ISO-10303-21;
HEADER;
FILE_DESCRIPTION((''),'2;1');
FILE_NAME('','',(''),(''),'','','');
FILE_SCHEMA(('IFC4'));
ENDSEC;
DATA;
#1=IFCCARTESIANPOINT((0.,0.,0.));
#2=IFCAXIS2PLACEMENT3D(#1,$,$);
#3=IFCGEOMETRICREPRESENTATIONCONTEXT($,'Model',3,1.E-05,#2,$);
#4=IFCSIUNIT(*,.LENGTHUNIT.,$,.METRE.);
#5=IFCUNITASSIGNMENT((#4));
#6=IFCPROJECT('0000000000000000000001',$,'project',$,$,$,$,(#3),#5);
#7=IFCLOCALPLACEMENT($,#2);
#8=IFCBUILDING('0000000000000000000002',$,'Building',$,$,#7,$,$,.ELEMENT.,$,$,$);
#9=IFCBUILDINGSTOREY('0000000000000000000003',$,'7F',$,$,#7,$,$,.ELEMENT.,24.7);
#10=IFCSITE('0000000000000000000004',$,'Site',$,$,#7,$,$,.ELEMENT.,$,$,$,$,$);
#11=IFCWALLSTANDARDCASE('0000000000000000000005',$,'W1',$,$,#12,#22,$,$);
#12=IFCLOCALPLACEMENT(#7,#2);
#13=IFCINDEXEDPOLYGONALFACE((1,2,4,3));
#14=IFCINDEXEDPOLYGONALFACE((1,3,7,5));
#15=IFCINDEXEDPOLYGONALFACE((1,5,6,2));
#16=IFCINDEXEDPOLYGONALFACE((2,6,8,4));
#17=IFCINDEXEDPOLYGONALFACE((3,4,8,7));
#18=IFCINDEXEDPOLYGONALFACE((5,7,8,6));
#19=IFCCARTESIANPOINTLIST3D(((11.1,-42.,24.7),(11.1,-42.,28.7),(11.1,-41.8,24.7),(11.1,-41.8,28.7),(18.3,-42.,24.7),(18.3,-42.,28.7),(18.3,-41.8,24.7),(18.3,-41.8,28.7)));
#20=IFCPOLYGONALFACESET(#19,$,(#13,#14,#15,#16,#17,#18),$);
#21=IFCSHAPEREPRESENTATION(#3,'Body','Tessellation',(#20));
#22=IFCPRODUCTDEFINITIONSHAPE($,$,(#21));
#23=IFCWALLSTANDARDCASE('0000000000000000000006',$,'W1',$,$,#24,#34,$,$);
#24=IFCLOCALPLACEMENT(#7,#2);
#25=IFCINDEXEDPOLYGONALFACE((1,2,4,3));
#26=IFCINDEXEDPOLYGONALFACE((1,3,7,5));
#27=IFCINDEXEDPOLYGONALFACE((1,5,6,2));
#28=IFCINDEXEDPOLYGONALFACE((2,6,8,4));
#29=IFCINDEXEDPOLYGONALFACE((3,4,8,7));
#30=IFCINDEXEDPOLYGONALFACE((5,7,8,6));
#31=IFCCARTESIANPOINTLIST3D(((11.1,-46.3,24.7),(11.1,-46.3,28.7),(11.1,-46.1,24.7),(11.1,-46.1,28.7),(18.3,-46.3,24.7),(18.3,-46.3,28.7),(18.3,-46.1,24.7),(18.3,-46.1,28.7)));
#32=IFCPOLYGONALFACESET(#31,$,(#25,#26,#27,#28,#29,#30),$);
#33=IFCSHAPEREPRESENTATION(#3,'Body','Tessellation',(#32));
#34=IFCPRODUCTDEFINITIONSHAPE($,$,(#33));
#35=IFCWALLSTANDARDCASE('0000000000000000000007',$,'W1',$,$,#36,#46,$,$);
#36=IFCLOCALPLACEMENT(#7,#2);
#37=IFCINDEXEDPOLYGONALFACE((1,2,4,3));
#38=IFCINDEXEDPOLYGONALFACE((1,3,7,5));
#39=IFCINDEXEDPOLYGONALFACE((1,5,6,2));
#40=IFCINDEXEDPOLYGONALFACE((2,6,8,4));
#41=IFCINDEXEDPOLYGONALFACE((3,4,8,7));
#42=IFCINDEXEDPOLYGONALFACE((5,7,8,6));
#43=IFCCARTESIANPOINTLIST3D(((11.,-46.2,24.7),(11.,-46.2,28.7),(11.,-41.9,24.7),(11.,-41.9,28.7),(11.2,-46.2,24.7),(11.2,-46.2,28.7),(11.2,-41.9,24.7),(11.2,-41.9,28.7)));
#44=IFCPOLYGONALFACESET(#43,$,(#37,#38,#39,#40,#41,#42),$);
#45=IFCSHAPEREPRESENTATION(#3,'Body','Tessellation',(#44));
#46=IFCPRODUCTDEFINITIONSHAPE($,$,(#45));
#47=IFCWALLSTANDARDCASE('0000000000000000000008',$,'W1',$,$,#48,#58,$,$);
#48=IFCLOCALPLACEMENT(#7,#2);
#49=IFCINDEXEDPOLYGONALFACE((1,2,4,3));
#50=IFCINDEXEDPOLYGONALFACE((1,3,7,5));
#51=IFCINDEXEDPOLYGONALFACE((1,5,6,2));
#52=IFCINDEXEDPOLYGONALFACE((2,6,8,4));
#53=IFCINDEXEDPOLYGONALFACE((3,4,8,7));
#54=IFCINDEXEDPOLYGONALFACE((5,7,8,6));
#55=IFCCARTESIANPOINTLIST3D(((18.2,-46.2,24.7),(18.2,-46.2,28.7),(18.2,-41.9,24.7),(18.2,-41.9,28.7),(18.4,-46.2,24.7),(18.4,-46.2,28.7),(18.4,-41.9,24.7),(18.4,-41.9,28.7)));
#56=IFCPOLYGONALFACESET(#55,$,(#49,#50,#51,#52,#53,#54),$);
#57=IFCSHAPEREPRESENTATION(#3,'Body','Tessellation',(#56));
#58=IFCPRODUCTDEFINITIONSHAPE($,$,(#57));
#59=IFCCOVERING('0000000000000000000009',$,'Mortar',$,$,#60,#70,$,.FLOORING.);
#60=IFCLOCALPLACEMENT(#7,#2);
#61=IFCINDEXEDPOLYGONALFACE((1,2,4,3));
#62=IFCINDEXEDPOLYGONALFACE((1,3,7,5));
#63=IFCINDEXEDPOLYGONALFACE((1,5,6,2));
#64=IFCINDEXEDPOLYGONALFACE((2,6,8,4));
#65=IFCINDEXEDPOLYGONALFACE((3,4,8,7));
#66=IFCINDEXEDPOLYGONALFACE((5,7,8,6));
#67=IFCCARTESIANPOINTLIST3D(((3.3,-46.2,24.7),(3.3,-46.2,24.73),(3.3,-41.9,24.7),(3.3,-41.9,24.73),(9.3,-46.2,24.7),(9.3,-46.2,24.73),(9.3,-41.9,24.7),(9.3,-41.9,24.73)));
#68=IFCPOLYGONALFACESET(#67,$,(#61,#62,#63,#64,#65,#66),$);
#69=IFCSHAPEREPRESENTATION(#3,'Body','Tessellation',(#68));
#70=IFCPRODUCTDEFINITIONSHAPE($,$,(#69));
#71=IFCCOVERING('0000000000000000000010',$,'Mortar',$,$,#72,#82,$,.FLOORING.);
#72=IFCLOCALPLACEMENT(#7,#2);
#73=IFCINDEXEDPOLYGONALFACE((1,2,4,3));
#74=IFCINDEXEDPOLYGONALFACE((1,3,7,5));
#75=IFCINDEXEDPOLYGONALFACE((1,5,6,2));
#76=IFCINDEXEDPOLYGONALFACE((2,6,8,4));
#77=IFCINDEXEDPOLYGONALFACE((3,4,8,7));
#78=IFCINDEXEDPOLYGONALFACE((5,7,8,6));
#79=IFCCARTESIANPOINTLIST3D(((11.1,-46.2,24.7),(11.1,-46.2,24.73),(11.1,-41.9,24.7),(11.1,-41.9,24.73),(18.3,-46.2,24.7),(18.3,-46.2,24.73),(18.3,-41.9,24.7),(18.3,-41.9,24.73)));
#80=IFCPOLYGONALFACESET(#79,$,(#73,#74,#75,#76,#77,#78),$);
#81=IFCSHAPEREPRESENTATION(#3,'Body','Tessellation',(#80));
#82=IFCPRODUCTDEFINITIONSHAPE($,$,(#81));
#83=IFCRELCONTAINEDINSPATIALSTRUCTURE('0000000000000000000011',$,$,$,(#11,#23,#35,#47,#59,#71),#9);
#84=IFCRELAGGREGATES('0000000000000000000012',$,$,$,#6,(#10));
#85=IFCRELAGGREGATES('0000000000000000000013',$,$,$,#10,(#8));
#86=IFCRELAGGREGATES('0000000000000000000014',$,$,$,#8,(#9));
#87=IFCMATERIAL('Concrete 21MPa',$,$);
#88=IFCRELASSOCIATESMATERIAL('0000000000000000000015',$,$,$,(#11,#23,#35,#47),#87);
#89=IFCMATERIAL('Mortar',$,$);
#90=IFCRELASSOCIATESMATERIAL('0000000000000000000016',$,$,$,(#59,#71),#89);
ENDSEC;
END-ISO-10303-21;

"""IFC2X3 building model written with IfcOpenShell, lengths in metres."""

from ifc_helpers import new_model, si_unit, frame, origin, origin_2d, place, context, project, spatial, rectangle, extrude, material, element, save


model = new_model("IFC2X3")

# Units and contexts
model_context = context("Model", 3, precision=1e-05, world=origin())
ifc_project = project(units=[si_unit("LENGTHUNIT", "METRE")], contexts=[model_context])

# Site, building, storey
placement = place(None, origin())
site = spatial("IfcSite", under=ifc_project, at=placement, Name="Site", CompositionType="ELEMENT")
building = spatial("IfcBuilding", under=site, at=placement, Name="Building", CompositionType="ELEMENT")
storey = spatial("IfcBuildingStorey", under=building, at=placement, Name="7F", CompositionType="ELEMENT", Elevation=24.7)

# Shared definitions
ifc_material_1 = material(Name="Concrete 21MPa")

# Walls
for number, where, name in (
    (1, (14.7, -41.9, 24.7), "W1"),
    (2, (14.7, -46.2, 24.7), "W1"),
):
    element("IfcWallStandardCase", number, at=place(None, frame(where)), inside=storey, material=ifc_material_1, Name=name, context=model_context, shape_type="SweptSolid", body=[
        extrude(rectangle(XDim=7.2, YDim=0.2, at=origin_2d()), origin(), (0.0, 0.0, 1.0), 4.0),
    ])
for number, where, name in (
    (3, (11.1, -44.05, 24.7), "W1"),
    (4, (18.3, -44.05, 24.7), "W1"),
):
    element("IfcWallStandardCase", number, at=place(None, frame(where)), inside=storey, material=ifc_material_1, Name=name, context=model_context, shape_type="SweptSolid", body=[
        extrude(rectangle(XDim=0.2, YDim=4.3, at=origin_2d()), origin(), (0.0, 0.0, 1.0), 4.0),
    ])

# Coverings
ifc_material_2 = material(Name="Mortar")
covering_1_placement = place(None, frame((6.3, -44.05, 24.7)))
element("IfcCovering", 5, at=covering_1_placement, inside=storey, material=ifc_material_2, Name="Mortar", PredefinedType="FLOORING", context=model_context, shape_type="SweptSolid", body=[
    extrude(rectangle(XDim=6.0, YDim=4.3, at=origin_2d()), origin(), (0.0, 0.0, 1.0), 0.03),
])
covering_2_placement = place(None, frame((14.7, -44.05, 24.7)))
element("IfcCovering", 6, at=covering_2_placement, inside=storey, material=ifc_material_2, Name="Mortar", PredefinedType="FLOORING", context=model_context, shape_type="SweptSolid", body=[
    extrude(rectangle(XDim=7.2, YDim=4.3, at=origin_2d()), origin(), (0.0, 0.0, 1.0), 0.03),
])

save(model, "model.ifc")
